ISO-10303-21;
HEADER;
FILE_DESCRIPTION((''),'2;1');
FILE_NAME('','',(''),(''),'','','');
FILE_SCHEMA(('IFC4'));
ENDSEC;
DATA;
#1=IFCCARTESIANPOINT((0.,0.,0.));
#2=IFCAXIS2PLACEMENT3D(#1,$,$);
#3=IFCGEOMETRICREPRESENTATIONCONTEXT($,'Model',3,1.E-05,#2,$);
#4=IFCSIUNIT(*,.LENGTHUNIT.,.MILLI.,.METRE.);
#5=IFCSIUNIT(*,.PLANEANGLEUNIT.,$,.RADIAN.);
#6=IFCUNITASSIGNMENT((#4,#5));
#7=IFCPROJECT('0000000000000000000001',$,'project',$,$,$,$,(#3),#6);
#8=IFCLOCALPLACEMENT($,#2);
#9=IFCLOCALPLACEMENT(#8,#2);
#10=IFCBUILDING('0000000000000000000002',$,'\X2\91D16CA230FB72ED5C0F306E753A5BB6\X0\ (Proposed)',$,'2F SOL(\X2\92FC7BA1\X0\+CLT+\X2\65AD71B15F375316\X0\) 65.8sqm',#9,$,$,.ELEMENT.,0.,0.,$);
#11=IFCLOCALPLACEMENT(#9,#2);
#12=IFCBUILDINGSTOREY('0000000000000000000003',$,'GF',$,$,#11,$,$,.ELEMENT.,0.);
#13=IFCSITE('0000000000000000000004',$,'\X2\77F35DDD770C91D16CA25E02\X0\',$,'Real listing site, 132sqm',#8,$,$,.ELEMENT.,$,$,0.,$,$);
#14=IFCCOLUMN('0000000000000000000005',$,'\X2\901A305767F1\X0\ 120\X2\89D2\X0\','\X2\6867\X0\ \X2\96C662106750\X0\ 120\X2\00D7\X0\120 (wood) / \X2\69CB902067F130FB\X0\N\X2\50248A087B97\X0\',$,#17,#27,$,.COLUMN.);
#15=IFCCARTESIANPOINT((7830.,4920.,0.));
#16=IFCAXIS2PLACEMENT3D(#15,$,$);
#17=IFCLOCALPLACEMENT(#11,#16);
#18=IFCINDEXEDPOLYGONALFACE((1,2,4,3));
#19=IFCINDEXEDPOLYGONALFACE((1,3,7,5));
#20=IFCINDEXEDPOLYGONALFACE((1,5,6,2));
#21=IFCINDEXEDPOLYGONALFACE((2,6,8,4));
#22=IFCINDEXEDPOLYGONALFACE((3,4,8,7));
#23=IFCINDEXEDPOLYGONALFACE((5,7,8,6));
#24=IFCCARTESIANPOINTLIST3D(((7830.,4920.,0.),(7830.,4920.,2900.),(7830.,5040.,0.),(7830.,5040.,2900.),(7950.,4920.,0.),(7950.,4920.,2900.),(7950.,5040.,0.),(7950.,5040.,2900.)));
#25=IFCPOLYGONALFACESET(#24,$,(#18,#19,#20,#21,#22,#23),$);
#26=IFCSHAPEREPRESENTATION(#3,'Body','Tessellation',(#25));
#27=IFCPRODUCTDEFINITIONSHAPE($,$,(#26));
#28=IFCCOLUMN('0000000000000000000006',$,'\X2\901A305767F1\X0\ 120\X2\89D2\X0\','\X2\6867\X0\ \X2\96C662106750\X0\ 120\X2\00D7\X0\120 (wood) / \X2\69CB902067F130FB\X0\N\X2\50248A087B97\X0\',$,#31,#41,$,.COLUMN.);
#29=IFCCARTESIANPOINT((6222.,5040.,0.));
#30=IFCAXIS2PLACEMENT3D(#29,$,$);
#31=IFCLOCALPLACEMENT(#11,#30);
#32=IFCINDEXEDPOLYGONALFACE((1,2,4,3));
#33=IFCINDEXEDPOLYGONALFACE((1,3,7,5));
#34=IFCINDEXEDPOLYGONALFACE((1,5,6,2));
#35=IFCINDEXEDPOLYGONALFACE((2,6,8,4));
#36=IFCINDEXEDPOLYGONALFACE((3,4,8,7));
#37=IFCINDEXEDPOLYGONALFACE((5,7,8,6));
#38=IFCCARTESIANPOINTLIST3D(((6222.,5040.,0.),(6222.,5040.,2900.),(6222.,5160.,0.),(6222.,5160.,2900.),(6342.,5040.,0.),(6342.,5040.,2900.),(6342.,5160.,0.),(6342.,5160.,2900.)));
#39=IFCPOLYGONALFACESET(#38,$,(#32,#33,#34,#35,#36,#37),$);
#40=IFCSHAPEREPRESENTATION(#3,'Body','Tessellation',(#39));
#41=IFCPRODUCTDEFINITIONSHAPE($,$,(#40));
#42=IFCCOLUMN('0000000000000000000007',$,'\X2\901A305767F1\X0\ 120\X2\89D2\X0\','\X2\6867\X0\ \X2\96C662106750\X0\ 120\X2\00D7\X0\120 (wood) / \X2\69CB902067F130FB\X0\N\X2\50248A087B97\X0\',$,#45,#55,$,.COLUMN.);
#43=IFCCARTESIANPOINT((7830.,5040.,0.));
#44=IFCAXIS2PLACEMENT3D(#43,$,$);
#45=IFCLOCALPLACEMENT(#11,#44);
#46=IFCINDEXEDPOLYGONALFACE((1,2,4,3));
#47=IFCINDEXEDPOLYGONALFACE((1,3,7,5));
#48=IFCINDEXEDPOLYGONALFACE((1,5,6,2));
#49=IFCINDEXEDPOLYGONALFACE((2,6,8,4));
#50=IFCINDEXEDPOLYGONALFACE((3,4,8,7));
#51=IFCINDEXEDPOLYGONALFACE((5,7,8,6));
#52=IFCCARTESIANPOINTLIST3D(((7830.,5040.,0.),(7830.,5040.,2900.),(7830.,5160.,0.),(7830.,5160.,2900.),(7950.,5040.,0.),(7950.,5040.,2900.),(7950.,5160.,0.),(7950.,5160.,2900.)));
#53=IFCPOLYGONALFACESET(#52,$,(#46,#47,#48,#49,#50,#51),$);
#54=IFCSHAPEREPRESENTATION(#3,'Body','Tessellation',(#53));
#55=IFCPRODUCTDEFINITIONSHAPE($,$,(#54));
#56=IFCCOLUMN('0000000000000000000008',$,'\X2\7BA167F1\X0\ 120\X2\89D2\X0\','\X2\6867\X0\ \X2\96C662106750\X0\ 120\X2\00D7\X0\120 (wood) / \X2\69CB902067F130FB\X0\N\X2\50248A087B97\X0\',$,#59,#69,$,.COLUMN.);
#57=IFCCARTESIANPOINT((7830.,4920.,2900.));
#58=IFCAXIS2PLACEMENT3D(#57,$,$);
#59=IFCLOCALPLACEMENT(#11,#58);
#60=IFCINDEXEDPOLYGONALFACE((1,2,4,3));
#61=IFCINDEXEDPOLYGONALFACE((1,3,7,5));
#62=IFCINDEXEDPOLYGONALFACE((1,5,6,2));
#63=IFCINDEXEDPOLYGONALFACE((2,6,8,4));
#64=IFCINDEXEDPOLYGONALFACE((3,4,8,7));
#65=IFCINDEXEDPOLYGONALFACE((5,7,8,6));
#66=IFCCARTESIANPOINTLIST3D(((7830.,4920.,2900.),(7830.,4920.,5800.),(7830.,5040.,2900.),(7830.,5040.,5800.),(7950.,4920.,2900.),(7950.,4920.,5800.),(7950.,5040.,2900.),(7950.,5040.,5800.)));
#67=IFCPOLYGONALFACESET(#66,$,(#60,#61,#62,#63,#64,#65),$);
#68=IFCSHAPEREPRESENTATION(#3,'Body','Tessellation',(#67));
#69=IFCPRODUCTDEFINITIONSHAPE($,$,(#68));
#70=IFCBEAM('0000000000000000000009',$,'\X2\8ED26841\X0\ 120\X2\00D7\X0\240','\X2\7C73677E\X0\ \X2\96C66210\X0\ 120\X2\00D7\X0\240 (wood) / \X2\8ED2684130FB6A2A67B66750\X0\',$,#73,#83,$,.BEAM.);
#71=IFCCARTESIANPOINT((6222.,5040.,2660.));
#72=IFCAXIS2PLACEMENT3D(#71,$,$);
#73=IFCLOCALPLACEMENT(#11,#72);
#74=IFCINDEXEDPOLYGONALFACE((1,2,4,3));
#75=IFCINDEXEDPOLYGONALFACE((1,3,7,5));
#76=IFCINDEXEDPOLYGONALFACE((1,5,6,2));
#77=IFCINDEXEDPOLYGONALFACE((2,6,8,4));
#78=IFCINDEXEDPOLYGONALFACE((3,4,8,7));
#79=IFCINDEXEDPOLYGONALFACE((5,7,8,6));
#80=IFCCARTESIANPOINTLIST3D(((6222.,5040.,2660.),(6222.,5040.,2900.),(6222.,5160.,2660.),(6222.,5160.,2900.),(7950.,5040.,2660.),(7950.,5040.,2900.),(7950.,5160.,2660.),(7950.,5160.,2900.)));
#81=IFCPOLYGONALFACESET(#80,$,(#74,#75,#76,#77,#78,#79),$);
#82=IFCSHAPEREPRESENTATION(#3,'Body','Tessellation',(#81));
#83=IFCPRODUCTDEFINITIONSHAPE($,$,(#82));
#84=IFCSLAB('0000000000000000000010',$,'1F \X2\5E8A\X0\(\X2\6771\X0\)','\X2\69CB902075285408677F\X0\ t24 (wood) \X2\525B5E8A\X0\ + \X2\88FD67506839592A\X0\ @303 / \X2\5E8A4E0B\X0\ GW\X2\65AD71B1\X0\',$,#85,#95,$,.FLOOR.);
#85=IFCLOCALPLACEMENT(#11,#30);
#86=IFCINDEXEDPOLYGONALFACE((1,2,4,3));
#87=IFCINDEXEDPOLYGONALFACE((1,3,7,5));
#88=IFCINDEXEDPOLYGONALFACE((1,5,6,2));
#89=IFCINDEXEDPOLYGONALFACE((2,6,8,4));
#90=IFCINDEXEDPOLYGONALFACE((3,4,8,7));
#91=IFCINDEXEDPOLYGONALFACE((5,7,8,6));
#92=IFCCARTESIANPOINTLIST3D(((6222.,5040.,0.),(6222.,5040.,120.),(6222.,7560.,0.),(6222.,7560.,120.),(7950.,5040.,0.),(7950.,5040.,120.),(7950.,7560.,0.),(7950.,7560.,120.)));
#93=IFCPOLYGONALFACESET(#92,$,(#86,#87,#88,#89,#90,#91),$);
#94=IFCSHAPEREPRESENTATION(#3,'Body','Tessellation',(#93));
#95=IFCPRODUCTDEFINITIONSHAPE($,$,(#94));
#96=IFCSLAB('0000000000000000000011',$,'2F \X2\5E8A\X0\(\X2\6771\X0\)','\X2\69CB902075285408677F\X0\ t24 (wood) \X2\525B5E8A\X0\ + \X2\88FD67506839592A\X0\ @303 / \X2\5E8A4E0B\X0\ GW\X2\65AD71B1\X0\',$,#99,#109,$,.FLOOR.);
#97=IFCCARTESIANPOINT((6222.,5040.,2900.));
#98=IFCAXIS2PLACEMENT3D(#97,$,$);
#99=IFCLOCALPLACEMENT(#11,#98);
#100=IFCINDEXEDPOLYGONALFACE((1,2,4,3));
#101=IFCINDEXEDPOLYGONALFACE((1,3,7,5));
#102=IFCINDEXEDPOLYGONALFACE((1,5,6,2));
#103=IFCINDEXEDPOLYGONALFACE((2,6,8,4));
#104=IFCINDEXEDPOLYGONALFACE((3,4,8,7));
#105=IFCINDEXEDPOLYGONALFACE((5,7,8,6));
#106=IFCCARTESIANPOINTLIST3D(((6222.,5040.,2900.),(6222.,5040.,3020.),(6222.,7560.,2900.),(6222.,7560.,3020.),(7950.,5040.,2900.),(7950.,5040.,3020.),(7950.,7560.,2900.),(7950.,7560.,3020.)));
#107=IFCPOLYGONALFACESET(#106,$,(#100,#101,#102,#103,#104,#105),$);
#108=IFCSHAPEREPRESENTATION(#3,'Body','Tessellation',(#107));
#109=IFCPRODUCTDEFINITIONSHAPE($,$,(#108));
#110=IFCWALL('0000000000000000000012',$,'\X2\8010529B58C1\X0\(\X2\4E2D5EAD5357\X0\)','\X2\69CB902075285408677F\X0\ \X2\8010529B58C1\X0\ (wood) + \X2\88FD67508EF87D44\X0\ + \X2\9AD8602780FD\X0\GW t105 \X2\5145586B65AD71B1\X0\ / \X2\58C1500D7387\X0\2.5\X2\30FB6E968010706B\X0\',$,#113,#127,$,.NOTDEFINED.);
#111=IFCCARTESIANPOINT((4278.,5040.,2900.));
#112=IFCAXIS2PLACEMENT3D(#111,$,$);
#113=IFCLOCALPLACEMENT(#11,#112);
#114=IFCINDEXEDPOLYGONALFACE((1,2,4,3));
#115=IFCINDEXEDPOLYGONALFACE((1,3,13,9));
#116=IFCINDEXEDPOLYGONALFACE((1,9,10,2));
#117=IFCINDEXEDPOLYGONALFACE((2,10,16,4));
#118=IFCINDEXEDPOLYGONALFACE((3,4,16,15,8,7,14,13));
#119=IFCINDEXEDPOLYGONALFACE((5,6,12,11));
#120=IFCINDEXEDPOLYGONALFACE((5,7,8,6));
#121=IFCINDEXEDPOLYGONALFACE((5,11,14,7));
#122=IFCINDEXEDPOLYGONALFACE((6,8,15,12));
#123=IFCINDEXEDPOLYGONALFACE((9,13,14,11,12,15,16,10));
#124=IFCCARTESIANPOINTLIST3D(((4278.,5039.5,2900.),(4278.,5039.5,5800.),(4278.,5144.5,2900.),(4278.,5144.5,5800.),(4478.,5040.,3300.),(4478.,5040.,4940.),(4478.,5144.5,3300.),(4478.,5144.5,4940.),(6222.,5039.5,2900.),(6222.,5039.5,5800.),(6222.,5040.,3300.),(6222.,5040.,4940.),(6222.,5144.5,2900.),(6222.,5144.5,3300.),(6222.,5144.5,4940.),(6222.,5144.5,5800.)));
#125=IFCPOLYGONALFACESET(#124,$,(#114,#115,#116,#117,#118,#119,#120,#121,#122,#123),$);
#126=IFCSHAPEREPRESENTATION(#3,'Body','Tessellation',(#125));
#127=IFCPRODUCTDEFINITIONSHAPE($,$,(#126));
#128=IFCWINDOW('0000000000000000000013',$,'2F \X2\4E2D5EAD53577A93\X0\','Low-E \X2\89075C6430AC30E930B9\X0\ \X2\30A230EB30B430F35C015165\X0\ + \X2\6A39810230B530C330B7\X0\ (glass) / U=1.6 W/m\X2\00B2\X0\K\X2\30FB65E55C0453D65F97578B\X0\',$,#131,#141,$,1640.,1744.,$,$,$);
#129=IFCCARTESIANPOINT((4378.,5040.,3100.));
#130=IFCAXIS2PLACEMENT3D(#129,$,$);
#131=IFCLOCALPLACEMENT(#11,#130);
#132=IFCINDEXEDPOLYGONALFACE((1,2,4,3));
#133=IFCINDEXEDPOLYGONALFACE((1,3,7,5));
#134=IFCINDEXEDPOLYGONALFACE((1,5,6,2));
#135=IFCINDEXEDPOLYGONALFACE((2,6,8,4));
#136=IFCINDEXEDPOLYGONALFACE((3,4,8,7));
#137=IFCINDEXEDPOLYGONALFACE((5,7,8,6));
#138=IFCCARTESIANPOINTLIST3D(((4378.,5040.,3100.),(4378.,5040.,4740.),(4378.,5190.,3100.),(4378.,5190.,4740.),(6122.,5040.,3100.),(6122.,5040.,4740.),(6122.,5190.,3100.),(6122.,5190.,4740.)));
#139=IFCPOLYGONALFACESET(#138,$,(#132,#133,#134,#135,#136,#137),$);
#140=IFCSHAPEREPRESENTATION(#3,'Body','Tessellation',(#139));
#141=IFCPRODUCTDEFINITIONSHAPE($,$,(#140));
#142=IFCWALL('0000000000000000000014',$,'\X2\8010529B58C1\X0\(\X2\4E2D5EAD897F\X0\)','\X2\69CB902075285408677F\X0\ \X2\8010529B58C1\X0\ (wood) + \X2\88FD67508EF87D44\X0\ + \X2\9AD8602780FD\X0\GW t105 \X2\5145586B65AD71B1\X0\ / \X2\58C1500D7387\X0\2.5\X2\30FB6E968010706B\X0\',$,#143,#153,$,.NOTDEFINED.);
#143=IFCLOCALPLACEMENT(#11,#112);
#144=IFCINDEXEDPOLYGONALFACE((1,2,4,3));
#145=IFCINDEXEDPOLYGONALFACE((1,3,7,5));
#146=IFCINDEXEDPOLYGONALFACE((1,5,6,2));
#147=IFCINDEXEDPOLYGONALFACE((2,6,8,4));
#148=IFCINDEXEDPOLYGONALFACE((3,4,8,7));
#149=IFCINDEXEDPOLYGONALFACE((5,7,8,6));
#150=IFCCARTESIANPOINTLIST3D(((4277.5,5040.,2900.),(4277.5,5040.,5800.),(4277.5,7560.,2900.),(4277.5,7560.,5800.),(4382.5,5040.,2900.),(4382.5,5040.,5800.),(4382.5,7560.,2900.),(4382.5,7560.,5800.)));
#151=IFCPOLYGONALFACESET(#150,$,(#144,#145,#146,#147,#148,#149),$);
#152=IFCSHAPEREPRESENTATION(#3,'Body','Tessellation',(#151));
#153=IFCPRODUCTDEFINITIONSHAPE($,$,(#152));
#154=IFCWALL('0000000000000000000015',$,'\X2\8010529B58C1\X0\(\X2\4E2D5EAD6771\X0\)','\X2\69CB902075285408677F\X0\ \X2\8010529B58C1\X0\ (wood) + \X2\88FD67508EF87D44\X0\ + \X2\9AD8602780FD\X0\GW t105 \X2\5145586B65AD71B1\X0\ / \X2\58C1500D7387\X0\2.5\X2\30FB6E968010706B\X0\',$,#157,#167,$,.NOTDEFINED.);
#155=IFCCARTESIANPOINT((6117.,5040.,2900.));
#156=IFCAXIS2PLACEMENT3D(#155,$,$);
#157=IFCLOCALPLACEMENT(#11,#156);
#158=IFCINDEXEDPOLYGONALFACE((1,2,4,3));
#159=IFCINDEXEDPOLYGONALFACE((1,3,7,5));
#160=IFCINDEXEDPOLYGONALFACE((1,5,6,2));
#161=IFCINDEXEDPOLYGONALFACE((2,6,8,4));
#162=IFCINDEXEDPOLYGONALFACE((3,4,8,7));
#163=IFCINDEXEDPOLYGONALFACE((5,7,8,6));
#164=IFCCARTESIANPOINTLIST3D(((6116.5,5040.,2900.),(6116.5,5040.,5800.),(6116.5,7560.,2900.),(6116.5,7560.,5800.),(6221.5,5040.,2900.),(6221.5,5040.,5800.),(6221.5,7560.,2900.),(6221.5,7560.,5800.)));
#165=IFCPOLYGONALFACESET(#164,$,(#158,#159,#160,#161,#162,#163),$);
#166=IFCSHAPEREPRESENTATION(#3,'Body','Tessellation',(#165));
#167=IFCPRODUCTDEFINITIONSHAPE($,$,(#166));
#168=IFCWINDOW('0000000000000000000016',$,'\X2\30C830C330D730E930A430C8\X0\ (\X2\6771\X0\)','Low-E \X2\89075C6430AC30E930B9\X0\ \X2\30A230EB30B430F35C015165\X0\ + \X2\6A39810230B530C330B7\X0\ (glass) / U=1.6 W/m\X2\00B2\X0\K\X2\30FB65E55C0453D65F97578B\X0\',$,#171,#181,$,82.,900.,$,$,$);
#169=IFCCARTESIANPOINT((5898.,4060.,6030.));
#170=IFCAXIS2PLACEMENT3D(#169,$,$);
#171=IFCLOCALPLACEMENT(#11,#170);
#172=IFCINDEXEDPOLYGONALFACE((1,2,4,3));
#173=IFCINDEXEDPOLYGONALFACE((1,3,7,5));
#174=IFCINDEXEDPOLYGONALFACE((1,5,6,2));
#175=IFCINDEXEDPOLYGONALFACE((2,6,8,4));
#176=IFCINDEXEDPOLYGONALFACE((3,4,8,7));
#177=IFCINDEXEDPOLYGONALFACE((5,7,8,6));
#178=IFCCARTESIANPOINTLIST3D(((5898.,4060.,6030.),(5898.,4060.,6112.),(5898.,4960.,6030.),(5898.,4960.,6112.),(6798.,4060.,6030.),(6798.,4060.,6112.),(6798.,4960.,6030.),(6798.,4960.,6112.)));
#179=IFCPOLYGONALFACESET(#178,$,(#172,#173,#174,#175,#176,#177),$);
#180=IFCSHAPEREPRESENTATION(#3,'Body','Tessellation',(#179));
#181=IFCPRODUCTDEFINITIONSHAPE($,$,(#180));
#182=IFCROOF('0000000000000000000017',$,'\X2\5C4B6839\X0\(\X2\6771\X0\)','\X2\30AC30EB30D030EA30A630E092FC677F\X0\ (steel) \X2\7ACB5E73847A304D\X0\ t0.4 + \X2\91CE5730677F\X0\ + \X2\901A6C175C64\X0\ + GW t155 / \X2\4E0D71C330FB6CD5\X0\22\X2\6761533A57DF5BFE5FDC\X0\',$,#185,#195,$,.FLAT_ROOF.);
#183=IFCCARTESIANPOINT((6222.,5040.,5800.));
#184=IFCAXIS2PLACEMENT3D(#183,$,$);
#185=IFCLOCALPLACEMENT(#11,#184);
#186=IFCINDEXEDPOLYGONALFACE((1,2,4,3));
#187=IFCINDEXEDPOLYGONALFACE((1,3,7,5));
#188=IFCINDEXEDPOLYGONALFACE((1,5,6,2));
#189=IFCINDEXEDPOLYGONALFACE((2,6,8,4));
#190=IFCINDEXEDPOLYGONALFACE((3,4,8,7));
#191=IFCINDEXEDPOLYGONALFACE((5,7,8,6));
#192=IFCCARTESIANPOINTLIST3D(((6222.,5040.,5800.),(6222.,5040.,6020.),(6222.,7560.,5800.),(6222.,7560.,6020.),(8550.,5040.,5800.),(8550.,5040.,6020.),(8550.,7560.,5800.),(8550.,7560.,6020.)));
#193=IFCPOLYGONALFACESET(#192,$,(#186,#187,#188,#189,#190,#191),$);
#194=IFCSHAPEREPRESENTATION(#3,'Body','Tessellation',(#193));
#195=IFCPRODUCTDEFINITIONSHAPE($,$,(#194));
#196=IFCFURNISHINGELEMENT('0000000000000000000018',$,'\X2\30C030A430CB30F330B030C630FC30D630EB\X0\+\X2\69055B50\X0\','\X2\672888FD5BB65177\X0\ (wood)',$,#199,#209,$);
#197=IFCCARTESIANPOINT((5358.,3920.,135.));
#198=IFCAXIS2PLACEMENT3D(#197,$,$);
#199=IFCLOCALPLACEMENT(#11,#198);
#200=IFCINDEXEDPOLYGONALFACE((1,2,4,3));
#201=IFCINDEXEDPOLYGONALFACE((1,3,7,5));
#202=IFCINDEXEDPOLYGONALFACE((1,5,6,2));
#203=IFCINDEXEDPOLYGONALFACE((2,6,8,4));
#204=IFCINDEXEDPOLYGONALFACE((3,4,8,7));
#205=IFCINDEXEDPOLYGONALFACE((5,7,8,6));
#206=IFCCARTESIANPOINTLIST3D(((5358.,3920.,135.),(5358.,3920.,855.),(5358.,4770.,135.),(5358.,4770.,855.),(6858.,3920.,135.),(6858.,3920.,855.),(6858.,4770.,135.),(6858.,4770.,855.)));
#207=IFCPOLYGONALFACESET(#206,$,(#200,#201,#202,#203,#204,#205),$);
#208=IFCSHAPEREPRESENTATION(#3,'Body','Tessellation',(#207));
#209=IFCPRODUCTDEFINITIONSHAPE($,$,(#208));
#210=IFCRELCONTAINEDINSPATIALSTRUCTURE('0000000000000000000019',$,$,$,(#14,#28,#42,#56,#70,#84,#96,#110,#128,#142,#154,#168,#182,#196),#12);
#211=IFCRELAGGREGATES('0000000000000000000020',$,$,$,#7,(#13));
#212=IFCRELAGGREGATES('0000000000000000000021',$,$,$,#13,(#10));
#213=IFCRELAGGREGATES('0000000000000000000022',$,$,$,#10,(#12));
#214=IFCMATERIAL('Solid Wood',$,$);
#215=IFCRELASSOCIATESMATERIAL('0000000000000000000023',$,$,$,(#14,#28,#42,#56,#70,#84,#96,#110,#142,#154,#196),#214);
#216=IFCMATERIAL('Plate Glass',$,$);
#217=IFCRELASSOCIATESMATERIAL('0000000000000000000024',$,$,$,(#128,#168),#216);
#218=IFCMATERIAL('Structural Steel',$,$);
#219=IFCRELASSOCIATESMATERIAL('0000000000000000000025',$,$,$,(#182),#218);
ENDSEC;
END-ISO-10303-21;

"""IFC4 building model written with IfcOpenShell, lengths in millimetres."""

from ifc_helpers import new_model, si_unit, frame, frame_2d, origin, place, context, project, spatial, rectangle, extrude, material, element, fill, save


model = new_model("IFC4")

# Units and contexts
model_context = context("Model", 3, precision=1e-05, world=origin())
ifc_project = project(units=[si_unit("LENGTHUNIT", "METRE", prefix="MILLI"), si_unit("PLANEANGLEUNIT", "RADIAN")], contexts=[model_context])

# Site, building, storey
site_placement = place(None, origin())
site = spatial("IfcSite", under=ifc_project, at=site_placement, Name="石川県金沢市", ObjectType="Real listing site, 132sqm", CompositionType="ELEMENT", RefElevation=0.0)
building_placement = place(site_placement, origin())
building = spatial("IfcBuilding", under=site, at=building_placement, Name="金沢・狭小の町家 (Proposed)", ObjectType="2F SOL(鋼管+CLT+断熱強化) 65.8sqm", CompositionType="ELEMENT", ElevationOfRefHeight=0.0, ElevationOfTerrain=0.0)
storey_placement = place(building_placement, origin())
storey = spatial("IfcBuildingStorey", under=building, at=storey_placement, Name="GF", CompositionType="ELEMENT", Elevation=0.0)

# Columns
ifc_material_1 = material(Name="Solid Wood")
column_1_placement = place(storey_placement, frame((7830.0, 4920.0, 0.0)))
element("IfcColumn", 1, at=column_1_placement, inside=storey, material=ifc_material_1, Name="通し柱 120角", Description="桧 集成材 120×120 (wood) / 構造柱・N値計算", PredefinedType="COLUMN", context=model_context, shape_type="SweptSolid", body=[
    extrude(rectangle(XDim=120.0, YDim=120.0, at=frame_2d((60.0, 60.0))), frame((7830.0, 4920.0, 0.0)), (0.0, 0.0, 1.0), 2900.0),
])
column_2_placement = place(storey_placement, frame((6222.0, 5040.0, 0.0)))
element("IfcColumn", 2, at=column_2_placement, inside=storey, material=ifc_material_1, Name="通し柱 120角", Description="桧 集成材 120×120 (wood) / 構造柱・N値計算", PredefinedType="COLUMN", context=model_context, shape_type="SweptSolid", body=[
    extrude(rectangle(XDim=120.0, YDim=120.0, at=frame_2d((60.0, 60.0))), frame((6222.0, 5040.0, 0.0)), (0.0, 0.0, 1.0), 2900.0),
])
column_3_placement = place(storey_placement, frame((7830.0, 5040.0, 0.0)))
element("IfcColumn", 3, at=column_3_placement, inside=storey, material=ifc_material_1, Name="通し柱 120角", Description="桧 集成材 120×120 (wood) / 構造柱・N値計算", PredefinedType="COLUMN", context=model_context, shape_type="SweptSolid", body=[
    extrude(rectangle(XDim=120.0, YDim=120.0, at=frame_2d((60.0, 60.0))), frame((7830.0, 5040.0, 0.0)), (0.0, 0.0, 1.0), 2900.0),
])
column_4_placement = place(storey_placement, frame((7830.0, 4920.0, 2900.0)))
element("IfcColumn", 4, at=column_4_placement, inside=storey, material=ifc_material_1, Name="管柱 120角", Description="桧 集成材 120×120 (wood) / 構造柱・N値計算", PredefinedType="COLUMN", context=model_context, shape_type="SweptSolid", body=[
    extrude(rectangle(XDim=120.0, YDim=120.0, at=frame_2d((60.0, 60.0))), frame((7830.0, 4920.0, 2900.0)), (0.0, 0.0, 1.0), 2900.0),
])

# Beam
beam_1_placement = place(storey_placement, frame((6222.0, 5040.0, 2660.0)))
element("IfcBeam", 5, at=beam_1_placement, inside=storey, material=ifc_material_1, Name="軒桁 120×240", Description="米松 集成 120×240 (wood) / 軒桁・横架材", PredefinedType="BEAM", context=model_context, shape_type="SweptSolid", body=[
    extrude(rectangle(XDim=1728.0, YDim=120.0, at=frame_2d((864.0, 60.0))), frame((6222.0, 5040.0, 2660.0)), (0.0, 0.0, 1.0), 240.0),
])

# Slabs
slab_1_placement = place(storey_placement, frame((6222.0, 5040.0, 0.0)))
element("IfcSlab", 6, at=slab_1_placement, inside=storey, material=ifc_material_1, Name="1F 床(東)", Description="構造用合板 t24 (wood) 剛床 + 製材根太 @303 / 床下 GW断熱", PredefinedType="FLOOR", context=model_context, shape_type="SweptSolid", body=[
    extrude(rectangle(XDim=1728.0, YDim=2520.0, at=frame_2d((864.0, 1260.0))), frame((6222.0, 5040.0, 0.0)), (0.0, 0.0, 1.0), 120.0),
])
slab_2_placement = place(storey_placement, frame((6222.0, 5040.0, 2900.0)))
element("IfcSlab", 7, at=slab_2_placement, inside=storey, material=ifc_material_1, Name="2F 床(東)", Description="構造用合板 t24 (wood) 剛床 + 製材根太 @303 / 床下 GW断熱", PredefinedType="FLOOR", context=model_context, shape_type="SweptSolid", body=[
    extrude(rectangle(XDim=1728.0, YDim=2520.0, at=frame_2d((864.0, 1260.0))), frame((6222.0, 5040.0, 2900.0)), (0.0, 0.0, 1.0), 120.0),
])

# Wall, opening, window
wall_1_placement = place(storey_placement, frame((4278.0, 5040.0, 2900.0)))
wall_1 = element("IfcWall", 8, at=wall_1_placement, inside=storey, material=ifc_material_1, Name="耐力壁(中庭南)", Description="構造用合板 耐力壁 (wood) + 製材軸組 + 高性能GW t105 充填断熱 / 壁倍率2.5・準耐火", PredefinedType="NOTDEFINED", context=model_context, shape_type="SweptSolid", body=[
    extrude(rectangle(XDim=1944.0, YDim=105.0, at=frame_2d((972.0, 52.0))), frame((4278.0, 5040.0, 2900.0)), (0.0, 0.0, 1.0), 2900.0),
])
opening_placement = place(storey_placement, frame((4378.0, 5040.0, 3100.0)))
opening = element("IfcOpeningElement", 9, at=opening_placement, cuts=wall_1, PredefinedType="NOTDEFINED", context=model_context, shape_type="SweptSolid", body=[
    extrude(rectangle(XDim=1744.0, YDim=150.0, at=frame_2d((872.0, 75.0))), frame((4378.0, 5040.0, 3100.0)), (0.0, 0.0, 1.0), 1640.0),
])
ifc_material_2 = material(Name="Plate Glass")
window_1_placement = place(storey_placement, frame((4378.0, 5040.0, 3100.0)))
window_1 = element("IfcWindow", 10, at=window_1_placement, inside=storey, material=ifc_material_2, Name="2F 中庭南窓", Description="Low-E 複層ガラス アルゴン封入 + 樹脂サッシ (glass) / U=1.6 W/m²K・日射取得型", OverallHeight=1640.0, OverallWidth=1744.0, context=model_context, shape_type="SweptSolid", body=[
    extrude(rectangle(XDim=1744.0, YDim=150.0, at=frame_2d((872.0, 75.0))), frame((4378.0, 5040.0, 3100.0)), (0.0, 0.0, 1.0), 1640.0),
])
fill(opening, window_1)

# Walls
wall_2_placement = place(storey_placement, frame((4278.0, 5040.0, 2900.0)))
element("IfcWall", 11, at=wall_2_placement, inside=storey, material=ifc_material_1, Name="耐力壁(中庭西)", Description="構造用合板 耐力壁 (wood) + 製材軸組 + 高性能GW t105 充填断熱 / 壁倍率2.5・準耐火", PredefinedType="NOTDEFINED", context=model_context, shape_type="SweptSolid", body=[
    extrude(rectangle(XDim=105.0, YDim=2520.0, at=frame_2d((52.0, 1260.0))), frame((4278.0, 5040.0, 2900.0)), (0.0, 0.0, 1.0), 2900.0),
])
wall_3_placement = place(storey_placement, frame((6117.0, 5040.0, 2900.0)))
element("IfcWall", 12, at=wall_3_placement, inside=storey, material=ifc_material_1, Name="耐力壁(中庭東)", Description="構造用合板 耐力壁 (wood) + 製材軸組 + 高性能GW t105 充填断熱 / 壁倍率2.5・準耐火", PredefinedType="NOTDEFINED", context=model_context, shape_type="SweptSolid", body=[
    extrude(rectangle(XDim=105.0, YDim=2520.0, at=frame_2d((52.0, 1260.0))), frame((6117.0, 5040.0, 2900.0)), (0.0, 0.0, 1.0), 2900.0),
])

# Window
window_2_placement = place(storey_placement, frame((5898.0, 4060.0, 6030.0)))
element("IfcWindow", 13, at=window_2_placement, inside=storey, material=ifc_material_2, Name="トップライト (東)", Description="Low-E 複層ガラス アルゴン封入 + 樹脂サッシ (glass) / U=1.6 W/m²K・日射取得型", OverallHeight=82.0, OverallWidth=900.0, context=model_context, shape_type="SweptSolid", body=[
    extrude(rectangle(XDim=900.0, YDim=900.0, at=frame_2d((450.0, 450.0))), frame((5898.0, 4060.0, 6030.0)), (0.0, 0.0, 1.0), 82.0),
])

# Roof
ifc_material_3 = material(Name="Structural Steel")
for number, where, name in (
    (14, (6222.0, 5040.0, 5800.0), "屋根(東)"),
):
    element("IfcRoof", number, at=place(storey_placement, frame(where)), inside=storey, material=ifc_material_3, Name=name, Description="ガルバリウム鋼板 (steel) 立平葺き t0.4 + 野地板 + 通気層 + GW t155 / 不燃・法22条区域対応", PredefinedType="FLAT_ROOF", context=model_context, shape_type="SweptSolid", body=[
        extrude(rectangle(XDim=2328.0, YDim=2520.0, at=frame_2d((1164.0, 1260.0))), frame((6222.0, 5040.0, 5800.0)), (0.0, 0.0, 1.0), 220.0),
    ])

# Furnishing element
furnishing_1_placement = place(storey_placement, frame((5358.0, 3920.0, 135.0)))
element("IfcFurnishingElement", 15, at=furnishing_1_placement, inside=storey, material=ifc_material_1, Name="ダイニングテーブル+椅子", Description="木製家具 (wood)", context=model_context, shape_type="SweptSolid", body=[
    extrude(rectangle(XDim=1500.0, YDim=850.0, at=frame_2d((750.0, 425.0))), frame((5358.0, 3920.0, 135.0)), (0.0, 0.0, 1.0), 720.0),
])

save(model, "model.ifc")
